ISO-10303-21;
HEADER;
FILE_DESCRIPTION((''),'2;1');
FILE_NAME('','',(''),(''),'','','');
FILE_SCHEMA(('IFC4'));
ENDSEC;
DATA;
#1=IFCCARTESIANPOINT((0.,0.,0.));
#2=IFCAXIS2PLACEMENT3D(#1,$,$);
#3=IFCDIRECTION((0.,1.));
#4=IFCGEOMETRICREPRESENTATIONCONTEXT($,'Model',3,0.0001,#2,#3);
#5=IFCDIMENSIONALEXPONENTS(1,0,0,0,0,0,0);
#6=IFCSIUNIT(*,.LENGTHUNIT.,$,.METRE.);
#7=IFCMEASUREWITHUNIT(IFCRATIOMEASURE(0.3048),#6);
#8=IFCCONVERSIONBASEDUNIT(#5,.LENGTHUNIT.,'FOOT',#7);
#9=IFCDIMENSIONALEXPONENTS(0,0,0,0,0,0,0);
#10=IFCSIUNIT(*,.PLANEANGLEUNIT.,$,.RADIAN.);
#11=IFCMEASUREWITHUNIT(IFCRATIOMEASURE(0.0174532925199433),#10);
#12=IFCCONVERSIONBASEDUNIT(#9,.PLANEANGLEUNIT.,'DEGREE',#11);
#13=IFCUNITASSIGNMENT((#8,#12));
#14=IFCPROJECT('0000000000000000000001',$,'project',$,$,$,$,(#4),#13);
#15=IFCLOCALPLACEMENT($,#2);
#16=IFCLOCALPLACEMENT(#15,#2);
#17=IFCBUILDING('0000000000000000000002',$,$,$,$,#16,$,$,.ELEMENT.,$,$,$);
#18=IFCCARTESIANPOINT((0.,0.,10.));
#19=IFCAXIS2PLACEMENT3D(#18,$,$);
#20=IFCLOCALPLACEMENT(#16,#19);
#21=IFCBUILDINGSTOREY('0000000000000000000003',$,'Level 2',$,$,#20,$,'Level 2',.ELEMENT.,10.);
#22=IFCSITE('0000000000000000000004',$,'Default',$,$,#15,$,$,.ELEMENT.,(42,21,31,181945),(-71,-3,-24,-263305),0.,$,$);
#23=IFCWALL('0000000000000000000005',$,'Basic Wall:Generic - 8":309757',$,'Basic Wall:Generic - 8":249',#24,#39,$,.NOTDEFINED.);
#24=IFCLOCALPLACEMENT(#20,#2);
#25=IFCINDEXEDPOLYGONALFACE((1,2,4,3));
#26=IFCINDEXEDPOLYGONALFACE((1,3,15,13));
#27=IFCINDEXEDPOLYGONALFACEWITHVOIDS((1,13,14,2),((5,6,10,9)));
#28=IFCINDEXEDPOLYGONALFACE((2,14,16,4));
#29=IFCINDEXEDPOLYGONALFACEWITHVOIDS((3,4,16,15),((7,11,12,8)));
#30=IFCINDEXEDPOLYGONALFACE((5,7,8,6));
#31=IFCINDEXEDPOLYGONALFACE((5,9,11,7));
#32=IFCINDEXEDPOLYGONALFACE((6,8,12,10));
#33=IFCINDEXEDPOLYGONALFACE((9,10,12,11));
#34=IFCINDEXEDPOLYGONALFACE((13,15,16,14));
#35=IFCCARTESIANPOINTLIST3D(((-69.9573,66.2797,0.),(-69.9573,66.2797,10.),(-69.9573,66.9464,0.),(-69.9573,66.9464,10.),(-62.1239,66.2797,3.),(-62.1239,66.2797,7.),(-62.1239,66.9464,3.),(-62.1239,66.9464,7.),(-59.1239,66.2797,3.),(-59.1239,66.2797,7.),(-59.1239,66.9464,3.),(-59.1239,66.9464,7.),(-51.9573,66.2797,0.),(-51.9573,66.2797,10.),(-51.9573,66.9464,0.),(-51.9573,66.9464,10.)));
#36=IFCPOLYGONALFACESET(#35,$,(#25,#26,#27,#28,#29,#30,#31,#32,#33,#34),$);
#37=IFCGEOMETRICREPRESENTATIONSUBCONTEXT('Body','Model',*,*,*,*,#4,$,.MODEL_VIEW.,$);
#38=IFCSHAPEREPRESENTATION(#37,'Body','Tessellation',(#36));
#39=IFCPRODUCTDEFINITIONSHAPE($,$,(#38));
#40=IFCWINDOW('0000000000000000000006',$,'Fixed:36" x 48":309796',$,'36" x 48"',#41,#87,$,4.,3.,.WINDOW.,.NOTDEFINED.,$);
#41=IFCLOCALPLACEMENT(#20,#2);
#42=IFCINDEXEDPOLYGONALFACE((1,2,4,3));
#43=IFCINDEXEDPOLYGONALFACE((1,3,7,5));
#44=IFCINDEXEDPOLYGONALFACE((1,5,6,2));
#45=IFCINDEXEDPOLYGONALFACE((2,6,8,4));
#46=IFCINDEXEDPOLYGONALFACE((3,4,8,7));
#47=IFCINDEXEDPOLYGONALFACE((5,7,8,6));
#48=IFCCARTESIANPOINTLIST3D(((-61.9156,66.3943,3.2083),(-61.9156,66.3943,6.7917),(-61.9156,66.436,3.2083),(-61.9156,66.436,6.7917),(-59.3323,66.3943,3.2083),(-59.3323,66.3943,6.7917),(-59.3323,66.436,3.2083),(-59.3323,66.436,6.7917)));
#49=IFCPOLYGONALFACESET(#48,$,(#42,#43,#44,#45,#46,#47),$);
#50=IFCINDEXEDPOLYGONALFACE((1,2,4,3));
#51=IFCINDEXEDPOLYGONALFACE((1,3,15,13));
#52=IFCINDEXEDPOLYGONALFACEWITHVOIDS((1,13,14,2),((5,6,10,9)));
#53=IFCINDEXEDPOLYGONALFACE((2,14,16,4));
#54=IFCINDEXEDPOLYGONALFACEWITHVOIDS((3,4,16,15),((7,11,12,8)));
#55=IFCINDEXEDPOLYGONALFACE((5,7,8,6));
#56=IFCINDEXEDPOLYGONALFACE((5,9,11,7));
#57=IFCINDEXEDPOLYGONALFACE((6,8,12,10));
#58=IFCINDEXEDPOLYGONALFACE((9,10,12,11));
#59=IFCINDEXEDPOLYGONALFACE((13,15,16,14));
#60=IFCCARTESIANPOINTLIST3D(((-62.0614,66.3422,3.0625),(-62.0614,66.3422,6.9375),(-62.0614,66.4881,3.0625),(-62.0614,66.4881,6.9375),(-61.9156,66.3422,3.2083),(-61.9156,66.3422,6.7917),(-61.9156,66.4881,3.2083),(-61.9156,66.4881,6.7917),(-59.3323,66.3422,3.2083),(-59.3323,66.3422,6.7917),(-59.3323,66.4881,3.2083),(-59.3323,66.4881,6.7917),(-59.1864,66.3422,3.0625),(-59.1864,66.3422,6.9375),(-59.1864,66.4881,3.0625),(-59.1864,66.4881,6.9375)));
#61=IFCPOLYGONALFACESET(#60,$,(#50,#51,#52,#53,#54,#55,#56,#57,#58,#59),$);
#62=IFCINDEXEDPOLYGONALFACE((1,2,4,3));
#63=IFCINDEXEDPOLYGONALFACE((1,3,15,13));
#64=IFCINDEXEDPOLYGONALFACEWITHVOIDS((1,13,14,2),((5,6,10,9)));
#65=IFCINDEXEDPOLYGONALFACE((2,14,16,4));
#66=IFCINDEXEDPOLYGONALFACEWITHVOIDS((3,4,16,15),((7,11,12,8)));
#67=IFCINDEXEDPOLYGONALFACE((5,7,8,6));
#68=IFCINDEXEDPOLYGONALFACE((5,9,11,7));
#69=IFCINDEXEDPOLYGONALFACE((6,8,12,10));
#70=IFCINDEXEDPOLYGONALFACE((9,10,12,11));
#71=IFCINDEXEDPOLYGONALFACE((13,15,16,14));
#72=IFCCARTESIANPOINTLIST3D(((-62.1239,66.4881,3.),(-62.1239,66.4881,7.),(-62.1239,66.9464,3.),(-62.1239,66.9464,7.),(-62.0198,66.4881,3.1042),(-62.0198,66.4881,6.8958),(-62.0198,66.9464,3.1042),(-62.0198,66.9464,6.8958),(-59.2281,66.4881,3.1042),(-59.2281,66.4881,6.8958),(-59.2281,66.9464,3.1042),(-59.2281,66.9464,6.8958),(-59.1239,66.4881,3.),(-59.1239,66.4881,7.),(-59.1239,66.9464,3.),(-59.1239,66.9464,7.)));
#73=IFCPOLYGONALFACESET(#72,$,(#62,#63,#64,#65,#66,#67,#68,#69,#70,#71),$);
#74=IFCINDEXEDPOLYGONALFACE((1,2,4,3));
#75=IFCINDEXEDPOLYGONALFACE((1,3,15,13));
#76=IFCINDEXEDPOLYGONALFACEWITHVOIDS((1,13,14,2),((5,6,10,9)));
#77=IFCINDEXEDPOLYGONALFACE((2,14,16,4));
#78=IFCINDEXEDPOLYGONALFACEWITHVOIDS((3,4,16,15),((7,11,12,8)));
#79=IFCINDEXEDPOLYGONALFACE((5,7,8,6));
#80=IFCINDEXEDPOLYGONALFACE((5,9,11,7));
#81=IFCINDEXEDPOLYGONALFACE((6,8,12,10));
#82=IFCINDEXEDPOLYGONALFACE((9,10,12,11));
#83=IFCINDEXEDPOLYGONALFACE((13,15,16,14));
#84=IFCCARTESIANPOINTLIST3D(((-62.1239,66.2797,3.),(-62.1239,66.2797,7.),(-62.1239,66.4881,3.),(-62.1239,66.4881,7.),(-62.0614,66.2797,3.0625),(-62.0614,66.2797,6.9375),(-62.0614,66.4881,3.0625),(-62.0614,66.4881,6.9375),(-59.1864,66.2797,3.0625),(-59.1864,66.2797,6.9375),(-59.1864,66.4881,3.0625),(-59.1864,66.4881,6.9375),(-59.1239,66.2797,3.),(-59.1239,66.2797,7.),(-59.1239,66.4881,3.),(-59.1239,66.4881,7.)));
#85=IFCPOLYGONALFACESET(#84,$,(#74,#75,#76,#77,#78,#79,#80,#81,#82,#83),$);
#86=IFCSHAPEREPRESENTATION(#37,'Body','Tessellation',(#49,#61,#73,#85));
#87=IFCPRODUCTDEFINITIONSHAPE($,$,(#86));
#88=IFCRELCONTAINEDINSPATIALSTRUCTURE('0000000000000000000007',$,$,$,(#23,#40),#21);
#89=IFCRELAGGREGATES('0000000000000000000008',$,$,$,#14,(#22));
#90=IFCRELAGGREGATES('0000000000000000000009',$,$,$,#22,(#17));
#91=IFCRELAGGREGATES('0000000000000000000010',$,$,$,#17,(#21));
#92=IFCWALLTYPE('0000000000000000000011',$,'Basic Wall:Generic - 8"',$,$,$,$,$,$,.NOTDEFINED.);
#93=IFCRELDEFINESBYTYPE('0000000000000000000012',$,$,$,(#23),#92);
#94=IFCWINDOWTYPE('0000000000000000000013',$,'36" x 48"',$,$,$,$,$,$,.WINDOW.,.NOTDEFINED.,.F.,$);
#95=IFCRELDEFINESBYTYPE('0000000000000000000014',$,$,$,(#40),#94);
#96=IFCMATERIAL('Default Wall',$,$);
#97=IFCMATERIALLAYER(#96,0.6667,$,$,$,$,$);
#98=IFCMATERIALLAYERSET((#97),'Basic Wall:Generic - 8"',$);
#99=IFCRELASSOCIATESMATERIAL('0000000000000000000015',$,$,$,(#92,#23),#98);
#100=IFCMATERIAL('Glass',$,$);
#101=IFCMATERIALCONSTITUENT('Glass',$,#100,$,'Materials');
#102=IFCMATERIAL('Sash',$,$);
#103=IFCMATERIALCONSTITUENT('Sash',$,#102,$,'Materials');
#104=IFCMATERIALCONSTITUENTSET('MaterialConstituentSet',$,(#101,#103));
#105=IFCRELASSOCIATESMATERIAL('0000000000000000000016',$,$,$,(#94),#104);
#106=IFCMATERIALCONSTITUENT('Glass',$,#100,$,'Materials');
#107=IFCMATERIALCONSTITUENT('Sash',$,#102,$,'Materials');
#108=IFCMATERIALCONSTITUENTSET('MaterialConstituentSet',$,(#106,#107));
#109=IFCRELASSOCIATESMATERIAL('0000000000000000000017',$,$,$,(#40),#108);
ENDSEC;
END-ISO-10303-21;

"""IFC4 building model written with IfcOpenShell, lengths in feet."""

from ifc_helpers import new_model, entity, si_unit, converted_unit, direction, frame, frame_2d, origin, place, context, subcontext, project, spatial, polyline, rectangle, outline, extrude, source, transform, mapped, material, layer, layer_set, layer_usage, constituent, constituent_set, type_object, type_shapes, element, fill, save


model = new_model("IFC4")

# Units and contexts
model_context = context("Model", 3, precision=0.0001, world=origin(), true_north=direction((0.0, 1.0)))
body_context = subcontext(model_context, "Body", "Model", "MODEL_VIEW")
ifc_project = project(units=[converted_unit("LENGTHUNIT", "FOOT", entity("IfcRatioMeasure", 0.3048), si_unit("LENGTHUNIT", "METRE"), dimensions=[1, 0, 0, 0, 0, 0, 0]), converted_unit("PLANEANGLEUNIT", "DEGREE", entity("IfcRatioMeasure", 0.0174532925199433), si_unit("PLANEANGLEUNIT", "RADIAN"), dimensions=[0, 0, 0, 0, 0, 0, 0])], contexts=[model_context])

# Site, building, storey
site_placement = place(None, origin())
site = spatial("IfcSite", under=ifc_project, at=site_placement, Name="Default", CompositionType="ELEMENT", RefLatitude=(42, 21, 31, 181945), RefLongitude=(-71, -3, -24, -263305), RefElevation=0.0)
building_placement = place(site_placement, origin())
building = spatial("IfcBuilding", under=site, at=building_placement, CompositionType="ELEMENT")
storey_placement = place(building_placement, frame((0.0, 0.0, 10.0)))
storey = spatial("IfcBuildingStorey", under=building, at=storey_placement, Name="Level 2", LongName="Level 2", CompositionType="ELEMENT", Elevation=10.0)

# Wall, opening, window
ifc_material_1 = material(Name="Default Wall")
ifc_layer = layer(ifc_material_1, 0.6667)
ifc_layer_set = layer_set([ifc_layer], Name="Basic Wall:Generic - 8\"")
ifc_layer_usage_1 = layer_usage(ifc_layer_set, "AXIS2", "NEGATIVE", 0.3333)
wall_type = type_object("IfcWallType", Name="Basic Wall:Generic - 8\"", PredefinedType="NOTDEFINED", material=ifc_layer_set)
wall_1_placement = place(storey_placement, frame((-69.9573, 66.6131, 0.0)))
wall_1 = element("IfcWall", 1, at=wall_1_placement, inside=storey, type_object=wall_type, material=ifc_layer_usage_1, Name="Basic Wall:Generic - 8\":309757", ObjectType="Basic Wall:Generic - 8\":249", PredefinedType="NOTDEFINED", context=body_context, shape_type="SweptSolid", body=[
    extrude(rectangle(XDim=18.0, YDim=0.6667, at=frame_2d((9.0, 0.0), x_axis=(-1.0, 0.0))), origin(), (0.0, 0.0, 1.0), 10.0),
])
opening_1_placement = place(wall_1_placement, frame((10.8333, 0.3333, 3.0)))
opening_1 = element("IfcOpeningElement", 2, at=opening_1_placement, cuts=wall_1, ObjectType="Opening", PredefinedType="OPENING", context=body_context, shape_type="SweptSolid", body=[
    extrude(rectangle(XDim=4.0, YDim=3.0, at=frame_2d((2.0, 1.5), x_axis=(-1.0, 0.0))), frame((0.0, 0.0, 0.0), z_axis=(0.0, -1.0, 0.0), x_axis=(0.0, 0.0, 1.0)), (0.0, 0.0, 1.0), 0.6667),
])
ifc_material_2 = material(Name="Glass")
ifc_constituent_1 = constituent(ifc_material_2, Name="Glass", Category="Materials")
ifc_material_3 = material(Name="Sash")
ifc_constituent_2 = constituent(ifc_material_3, Name="Sash", Category="Materials")
ifc_constituent_set_1 = constituent_set(constituents=[ifc_constituent_1, ifc_constituent_2], Name="MaterialConstituentSet")
ifc_constituent_3 = constituent(ifc_material_2, Name="Glass", Category="Materials")
ifc_constituent_4 = constituent(ifc_material_3, Name="Sash", Category="Materials")
ifc_constituent_set_2 = constituent_set(constituents=[ifc_constituent_3, ifc_constituent_4], Name="MaterialConstituentSet")
window_type_1 = type_object("IfcWindowType", Name="36\" x 48\"", ParameterTakesPrecedence=False, PartitioningType="NOTDEFINED", PredefinedType="WINDOW", material=ifc_constituent_set_2)
shared_shape_1 = source(origin(), body_context, "Body", "SweptSolid", [
    extrude(rectangle(XDim=0.0417, YDim=2.5833, at=frame_2d((0.0, 0.0), x_axis=(1.0, 0.0))), frame((1.5, 0.5312, 0.2083), z_axis=(0.0, 0.0, 1.0), x_axis=(0.0, 1.0, 0.0)), (0.0, 0.0, 1.0), 3.5833),
    extrude(outline(polyline([(-1.4375, -1.9375), (1.4375, -1.9375), (1.4375, 1.9375), (-1.4375, 1.9375), (-1.4375, -1.9375)]), holes=[polyline([(-1.2917, -1.7917), (-1.2917, 1.7917), (1.2917, 1.7917), (1.2917, -1.7917), (-1.2917, -1.7917)])]), frame((1.5, 0.4583, 2.0), z_axis=(0.0, 1.0, 0.0), x_axis=(1.0, 0.0, 0.0)), (0.0, 0.0, 1.0), 0.1458),
    extrude(outline(polyline([(-1.5, -2.0), (1.5, -2.0), (1.5, 2.0), (-1.5, 2.0), (-1.5, -2.0)]), holes=[polyline([(-1.3958, -1.8958), (-1.3958, 1.8958), (1.3958, 1.8958), (1.3958, -1.8958), (-1.3958, -1.8958)])]), frame((1.5, 0.0, 2.0), z_axis=(0.0, 1.0, 0.0), x_axis=(1.0, 0.0, 0.0)), (0.0, 0.0, 1.0), 0.4583),
    extrude(outline(polyline([(-2.0, -1.5), (2.0, -1.5), (2.0, 1.5), (-2.0, 1.5), (-2.0, -1.5)]), holes=[polyline([(-1.9375, -1.4375), (-1.9375, 1.4375), (1.9375, 1.4375), (1.9375, -1.4375), (-1.9375, -1.4375)])]), frame((1.5, 0.4583, 2.0), z_axis=(0.0, 1.0, 0.0), x_axis=(0.0, 0.0, -1.0)), (0.0, 0.0, 1.0), 0.2083),
])
type_shapes(window_type_1, [shared_shape_1])
window_1_placement = place(opening_1_placement, frame((0.0, 0.0, 0.0), z_axis=(0.0, 0.0, 1.0), x_axis=(-1.0, 0.0, 0.0)))
window_1 = element("IfcWindow", 3, at=window_1_placement, inside=storey, type_object=window_type_1, material=ifc_constituent_set_1, Name="Fixed:36\" x 48\":309796", ObjectType="36\" x 48\"", OverallHeight=4.0, OverallWidth=3.0, PartitioningType="NOTDEFINED", PredefinedType="WINDOW", context=body_context, shape_type="MappedRepresentation", body=[
    mapped(shared_shape_1, transform((0.0, 0.0, 0.0), scale=1.0)),
])
fill(opening_1, window_1)

save(model, "model.ifc")
